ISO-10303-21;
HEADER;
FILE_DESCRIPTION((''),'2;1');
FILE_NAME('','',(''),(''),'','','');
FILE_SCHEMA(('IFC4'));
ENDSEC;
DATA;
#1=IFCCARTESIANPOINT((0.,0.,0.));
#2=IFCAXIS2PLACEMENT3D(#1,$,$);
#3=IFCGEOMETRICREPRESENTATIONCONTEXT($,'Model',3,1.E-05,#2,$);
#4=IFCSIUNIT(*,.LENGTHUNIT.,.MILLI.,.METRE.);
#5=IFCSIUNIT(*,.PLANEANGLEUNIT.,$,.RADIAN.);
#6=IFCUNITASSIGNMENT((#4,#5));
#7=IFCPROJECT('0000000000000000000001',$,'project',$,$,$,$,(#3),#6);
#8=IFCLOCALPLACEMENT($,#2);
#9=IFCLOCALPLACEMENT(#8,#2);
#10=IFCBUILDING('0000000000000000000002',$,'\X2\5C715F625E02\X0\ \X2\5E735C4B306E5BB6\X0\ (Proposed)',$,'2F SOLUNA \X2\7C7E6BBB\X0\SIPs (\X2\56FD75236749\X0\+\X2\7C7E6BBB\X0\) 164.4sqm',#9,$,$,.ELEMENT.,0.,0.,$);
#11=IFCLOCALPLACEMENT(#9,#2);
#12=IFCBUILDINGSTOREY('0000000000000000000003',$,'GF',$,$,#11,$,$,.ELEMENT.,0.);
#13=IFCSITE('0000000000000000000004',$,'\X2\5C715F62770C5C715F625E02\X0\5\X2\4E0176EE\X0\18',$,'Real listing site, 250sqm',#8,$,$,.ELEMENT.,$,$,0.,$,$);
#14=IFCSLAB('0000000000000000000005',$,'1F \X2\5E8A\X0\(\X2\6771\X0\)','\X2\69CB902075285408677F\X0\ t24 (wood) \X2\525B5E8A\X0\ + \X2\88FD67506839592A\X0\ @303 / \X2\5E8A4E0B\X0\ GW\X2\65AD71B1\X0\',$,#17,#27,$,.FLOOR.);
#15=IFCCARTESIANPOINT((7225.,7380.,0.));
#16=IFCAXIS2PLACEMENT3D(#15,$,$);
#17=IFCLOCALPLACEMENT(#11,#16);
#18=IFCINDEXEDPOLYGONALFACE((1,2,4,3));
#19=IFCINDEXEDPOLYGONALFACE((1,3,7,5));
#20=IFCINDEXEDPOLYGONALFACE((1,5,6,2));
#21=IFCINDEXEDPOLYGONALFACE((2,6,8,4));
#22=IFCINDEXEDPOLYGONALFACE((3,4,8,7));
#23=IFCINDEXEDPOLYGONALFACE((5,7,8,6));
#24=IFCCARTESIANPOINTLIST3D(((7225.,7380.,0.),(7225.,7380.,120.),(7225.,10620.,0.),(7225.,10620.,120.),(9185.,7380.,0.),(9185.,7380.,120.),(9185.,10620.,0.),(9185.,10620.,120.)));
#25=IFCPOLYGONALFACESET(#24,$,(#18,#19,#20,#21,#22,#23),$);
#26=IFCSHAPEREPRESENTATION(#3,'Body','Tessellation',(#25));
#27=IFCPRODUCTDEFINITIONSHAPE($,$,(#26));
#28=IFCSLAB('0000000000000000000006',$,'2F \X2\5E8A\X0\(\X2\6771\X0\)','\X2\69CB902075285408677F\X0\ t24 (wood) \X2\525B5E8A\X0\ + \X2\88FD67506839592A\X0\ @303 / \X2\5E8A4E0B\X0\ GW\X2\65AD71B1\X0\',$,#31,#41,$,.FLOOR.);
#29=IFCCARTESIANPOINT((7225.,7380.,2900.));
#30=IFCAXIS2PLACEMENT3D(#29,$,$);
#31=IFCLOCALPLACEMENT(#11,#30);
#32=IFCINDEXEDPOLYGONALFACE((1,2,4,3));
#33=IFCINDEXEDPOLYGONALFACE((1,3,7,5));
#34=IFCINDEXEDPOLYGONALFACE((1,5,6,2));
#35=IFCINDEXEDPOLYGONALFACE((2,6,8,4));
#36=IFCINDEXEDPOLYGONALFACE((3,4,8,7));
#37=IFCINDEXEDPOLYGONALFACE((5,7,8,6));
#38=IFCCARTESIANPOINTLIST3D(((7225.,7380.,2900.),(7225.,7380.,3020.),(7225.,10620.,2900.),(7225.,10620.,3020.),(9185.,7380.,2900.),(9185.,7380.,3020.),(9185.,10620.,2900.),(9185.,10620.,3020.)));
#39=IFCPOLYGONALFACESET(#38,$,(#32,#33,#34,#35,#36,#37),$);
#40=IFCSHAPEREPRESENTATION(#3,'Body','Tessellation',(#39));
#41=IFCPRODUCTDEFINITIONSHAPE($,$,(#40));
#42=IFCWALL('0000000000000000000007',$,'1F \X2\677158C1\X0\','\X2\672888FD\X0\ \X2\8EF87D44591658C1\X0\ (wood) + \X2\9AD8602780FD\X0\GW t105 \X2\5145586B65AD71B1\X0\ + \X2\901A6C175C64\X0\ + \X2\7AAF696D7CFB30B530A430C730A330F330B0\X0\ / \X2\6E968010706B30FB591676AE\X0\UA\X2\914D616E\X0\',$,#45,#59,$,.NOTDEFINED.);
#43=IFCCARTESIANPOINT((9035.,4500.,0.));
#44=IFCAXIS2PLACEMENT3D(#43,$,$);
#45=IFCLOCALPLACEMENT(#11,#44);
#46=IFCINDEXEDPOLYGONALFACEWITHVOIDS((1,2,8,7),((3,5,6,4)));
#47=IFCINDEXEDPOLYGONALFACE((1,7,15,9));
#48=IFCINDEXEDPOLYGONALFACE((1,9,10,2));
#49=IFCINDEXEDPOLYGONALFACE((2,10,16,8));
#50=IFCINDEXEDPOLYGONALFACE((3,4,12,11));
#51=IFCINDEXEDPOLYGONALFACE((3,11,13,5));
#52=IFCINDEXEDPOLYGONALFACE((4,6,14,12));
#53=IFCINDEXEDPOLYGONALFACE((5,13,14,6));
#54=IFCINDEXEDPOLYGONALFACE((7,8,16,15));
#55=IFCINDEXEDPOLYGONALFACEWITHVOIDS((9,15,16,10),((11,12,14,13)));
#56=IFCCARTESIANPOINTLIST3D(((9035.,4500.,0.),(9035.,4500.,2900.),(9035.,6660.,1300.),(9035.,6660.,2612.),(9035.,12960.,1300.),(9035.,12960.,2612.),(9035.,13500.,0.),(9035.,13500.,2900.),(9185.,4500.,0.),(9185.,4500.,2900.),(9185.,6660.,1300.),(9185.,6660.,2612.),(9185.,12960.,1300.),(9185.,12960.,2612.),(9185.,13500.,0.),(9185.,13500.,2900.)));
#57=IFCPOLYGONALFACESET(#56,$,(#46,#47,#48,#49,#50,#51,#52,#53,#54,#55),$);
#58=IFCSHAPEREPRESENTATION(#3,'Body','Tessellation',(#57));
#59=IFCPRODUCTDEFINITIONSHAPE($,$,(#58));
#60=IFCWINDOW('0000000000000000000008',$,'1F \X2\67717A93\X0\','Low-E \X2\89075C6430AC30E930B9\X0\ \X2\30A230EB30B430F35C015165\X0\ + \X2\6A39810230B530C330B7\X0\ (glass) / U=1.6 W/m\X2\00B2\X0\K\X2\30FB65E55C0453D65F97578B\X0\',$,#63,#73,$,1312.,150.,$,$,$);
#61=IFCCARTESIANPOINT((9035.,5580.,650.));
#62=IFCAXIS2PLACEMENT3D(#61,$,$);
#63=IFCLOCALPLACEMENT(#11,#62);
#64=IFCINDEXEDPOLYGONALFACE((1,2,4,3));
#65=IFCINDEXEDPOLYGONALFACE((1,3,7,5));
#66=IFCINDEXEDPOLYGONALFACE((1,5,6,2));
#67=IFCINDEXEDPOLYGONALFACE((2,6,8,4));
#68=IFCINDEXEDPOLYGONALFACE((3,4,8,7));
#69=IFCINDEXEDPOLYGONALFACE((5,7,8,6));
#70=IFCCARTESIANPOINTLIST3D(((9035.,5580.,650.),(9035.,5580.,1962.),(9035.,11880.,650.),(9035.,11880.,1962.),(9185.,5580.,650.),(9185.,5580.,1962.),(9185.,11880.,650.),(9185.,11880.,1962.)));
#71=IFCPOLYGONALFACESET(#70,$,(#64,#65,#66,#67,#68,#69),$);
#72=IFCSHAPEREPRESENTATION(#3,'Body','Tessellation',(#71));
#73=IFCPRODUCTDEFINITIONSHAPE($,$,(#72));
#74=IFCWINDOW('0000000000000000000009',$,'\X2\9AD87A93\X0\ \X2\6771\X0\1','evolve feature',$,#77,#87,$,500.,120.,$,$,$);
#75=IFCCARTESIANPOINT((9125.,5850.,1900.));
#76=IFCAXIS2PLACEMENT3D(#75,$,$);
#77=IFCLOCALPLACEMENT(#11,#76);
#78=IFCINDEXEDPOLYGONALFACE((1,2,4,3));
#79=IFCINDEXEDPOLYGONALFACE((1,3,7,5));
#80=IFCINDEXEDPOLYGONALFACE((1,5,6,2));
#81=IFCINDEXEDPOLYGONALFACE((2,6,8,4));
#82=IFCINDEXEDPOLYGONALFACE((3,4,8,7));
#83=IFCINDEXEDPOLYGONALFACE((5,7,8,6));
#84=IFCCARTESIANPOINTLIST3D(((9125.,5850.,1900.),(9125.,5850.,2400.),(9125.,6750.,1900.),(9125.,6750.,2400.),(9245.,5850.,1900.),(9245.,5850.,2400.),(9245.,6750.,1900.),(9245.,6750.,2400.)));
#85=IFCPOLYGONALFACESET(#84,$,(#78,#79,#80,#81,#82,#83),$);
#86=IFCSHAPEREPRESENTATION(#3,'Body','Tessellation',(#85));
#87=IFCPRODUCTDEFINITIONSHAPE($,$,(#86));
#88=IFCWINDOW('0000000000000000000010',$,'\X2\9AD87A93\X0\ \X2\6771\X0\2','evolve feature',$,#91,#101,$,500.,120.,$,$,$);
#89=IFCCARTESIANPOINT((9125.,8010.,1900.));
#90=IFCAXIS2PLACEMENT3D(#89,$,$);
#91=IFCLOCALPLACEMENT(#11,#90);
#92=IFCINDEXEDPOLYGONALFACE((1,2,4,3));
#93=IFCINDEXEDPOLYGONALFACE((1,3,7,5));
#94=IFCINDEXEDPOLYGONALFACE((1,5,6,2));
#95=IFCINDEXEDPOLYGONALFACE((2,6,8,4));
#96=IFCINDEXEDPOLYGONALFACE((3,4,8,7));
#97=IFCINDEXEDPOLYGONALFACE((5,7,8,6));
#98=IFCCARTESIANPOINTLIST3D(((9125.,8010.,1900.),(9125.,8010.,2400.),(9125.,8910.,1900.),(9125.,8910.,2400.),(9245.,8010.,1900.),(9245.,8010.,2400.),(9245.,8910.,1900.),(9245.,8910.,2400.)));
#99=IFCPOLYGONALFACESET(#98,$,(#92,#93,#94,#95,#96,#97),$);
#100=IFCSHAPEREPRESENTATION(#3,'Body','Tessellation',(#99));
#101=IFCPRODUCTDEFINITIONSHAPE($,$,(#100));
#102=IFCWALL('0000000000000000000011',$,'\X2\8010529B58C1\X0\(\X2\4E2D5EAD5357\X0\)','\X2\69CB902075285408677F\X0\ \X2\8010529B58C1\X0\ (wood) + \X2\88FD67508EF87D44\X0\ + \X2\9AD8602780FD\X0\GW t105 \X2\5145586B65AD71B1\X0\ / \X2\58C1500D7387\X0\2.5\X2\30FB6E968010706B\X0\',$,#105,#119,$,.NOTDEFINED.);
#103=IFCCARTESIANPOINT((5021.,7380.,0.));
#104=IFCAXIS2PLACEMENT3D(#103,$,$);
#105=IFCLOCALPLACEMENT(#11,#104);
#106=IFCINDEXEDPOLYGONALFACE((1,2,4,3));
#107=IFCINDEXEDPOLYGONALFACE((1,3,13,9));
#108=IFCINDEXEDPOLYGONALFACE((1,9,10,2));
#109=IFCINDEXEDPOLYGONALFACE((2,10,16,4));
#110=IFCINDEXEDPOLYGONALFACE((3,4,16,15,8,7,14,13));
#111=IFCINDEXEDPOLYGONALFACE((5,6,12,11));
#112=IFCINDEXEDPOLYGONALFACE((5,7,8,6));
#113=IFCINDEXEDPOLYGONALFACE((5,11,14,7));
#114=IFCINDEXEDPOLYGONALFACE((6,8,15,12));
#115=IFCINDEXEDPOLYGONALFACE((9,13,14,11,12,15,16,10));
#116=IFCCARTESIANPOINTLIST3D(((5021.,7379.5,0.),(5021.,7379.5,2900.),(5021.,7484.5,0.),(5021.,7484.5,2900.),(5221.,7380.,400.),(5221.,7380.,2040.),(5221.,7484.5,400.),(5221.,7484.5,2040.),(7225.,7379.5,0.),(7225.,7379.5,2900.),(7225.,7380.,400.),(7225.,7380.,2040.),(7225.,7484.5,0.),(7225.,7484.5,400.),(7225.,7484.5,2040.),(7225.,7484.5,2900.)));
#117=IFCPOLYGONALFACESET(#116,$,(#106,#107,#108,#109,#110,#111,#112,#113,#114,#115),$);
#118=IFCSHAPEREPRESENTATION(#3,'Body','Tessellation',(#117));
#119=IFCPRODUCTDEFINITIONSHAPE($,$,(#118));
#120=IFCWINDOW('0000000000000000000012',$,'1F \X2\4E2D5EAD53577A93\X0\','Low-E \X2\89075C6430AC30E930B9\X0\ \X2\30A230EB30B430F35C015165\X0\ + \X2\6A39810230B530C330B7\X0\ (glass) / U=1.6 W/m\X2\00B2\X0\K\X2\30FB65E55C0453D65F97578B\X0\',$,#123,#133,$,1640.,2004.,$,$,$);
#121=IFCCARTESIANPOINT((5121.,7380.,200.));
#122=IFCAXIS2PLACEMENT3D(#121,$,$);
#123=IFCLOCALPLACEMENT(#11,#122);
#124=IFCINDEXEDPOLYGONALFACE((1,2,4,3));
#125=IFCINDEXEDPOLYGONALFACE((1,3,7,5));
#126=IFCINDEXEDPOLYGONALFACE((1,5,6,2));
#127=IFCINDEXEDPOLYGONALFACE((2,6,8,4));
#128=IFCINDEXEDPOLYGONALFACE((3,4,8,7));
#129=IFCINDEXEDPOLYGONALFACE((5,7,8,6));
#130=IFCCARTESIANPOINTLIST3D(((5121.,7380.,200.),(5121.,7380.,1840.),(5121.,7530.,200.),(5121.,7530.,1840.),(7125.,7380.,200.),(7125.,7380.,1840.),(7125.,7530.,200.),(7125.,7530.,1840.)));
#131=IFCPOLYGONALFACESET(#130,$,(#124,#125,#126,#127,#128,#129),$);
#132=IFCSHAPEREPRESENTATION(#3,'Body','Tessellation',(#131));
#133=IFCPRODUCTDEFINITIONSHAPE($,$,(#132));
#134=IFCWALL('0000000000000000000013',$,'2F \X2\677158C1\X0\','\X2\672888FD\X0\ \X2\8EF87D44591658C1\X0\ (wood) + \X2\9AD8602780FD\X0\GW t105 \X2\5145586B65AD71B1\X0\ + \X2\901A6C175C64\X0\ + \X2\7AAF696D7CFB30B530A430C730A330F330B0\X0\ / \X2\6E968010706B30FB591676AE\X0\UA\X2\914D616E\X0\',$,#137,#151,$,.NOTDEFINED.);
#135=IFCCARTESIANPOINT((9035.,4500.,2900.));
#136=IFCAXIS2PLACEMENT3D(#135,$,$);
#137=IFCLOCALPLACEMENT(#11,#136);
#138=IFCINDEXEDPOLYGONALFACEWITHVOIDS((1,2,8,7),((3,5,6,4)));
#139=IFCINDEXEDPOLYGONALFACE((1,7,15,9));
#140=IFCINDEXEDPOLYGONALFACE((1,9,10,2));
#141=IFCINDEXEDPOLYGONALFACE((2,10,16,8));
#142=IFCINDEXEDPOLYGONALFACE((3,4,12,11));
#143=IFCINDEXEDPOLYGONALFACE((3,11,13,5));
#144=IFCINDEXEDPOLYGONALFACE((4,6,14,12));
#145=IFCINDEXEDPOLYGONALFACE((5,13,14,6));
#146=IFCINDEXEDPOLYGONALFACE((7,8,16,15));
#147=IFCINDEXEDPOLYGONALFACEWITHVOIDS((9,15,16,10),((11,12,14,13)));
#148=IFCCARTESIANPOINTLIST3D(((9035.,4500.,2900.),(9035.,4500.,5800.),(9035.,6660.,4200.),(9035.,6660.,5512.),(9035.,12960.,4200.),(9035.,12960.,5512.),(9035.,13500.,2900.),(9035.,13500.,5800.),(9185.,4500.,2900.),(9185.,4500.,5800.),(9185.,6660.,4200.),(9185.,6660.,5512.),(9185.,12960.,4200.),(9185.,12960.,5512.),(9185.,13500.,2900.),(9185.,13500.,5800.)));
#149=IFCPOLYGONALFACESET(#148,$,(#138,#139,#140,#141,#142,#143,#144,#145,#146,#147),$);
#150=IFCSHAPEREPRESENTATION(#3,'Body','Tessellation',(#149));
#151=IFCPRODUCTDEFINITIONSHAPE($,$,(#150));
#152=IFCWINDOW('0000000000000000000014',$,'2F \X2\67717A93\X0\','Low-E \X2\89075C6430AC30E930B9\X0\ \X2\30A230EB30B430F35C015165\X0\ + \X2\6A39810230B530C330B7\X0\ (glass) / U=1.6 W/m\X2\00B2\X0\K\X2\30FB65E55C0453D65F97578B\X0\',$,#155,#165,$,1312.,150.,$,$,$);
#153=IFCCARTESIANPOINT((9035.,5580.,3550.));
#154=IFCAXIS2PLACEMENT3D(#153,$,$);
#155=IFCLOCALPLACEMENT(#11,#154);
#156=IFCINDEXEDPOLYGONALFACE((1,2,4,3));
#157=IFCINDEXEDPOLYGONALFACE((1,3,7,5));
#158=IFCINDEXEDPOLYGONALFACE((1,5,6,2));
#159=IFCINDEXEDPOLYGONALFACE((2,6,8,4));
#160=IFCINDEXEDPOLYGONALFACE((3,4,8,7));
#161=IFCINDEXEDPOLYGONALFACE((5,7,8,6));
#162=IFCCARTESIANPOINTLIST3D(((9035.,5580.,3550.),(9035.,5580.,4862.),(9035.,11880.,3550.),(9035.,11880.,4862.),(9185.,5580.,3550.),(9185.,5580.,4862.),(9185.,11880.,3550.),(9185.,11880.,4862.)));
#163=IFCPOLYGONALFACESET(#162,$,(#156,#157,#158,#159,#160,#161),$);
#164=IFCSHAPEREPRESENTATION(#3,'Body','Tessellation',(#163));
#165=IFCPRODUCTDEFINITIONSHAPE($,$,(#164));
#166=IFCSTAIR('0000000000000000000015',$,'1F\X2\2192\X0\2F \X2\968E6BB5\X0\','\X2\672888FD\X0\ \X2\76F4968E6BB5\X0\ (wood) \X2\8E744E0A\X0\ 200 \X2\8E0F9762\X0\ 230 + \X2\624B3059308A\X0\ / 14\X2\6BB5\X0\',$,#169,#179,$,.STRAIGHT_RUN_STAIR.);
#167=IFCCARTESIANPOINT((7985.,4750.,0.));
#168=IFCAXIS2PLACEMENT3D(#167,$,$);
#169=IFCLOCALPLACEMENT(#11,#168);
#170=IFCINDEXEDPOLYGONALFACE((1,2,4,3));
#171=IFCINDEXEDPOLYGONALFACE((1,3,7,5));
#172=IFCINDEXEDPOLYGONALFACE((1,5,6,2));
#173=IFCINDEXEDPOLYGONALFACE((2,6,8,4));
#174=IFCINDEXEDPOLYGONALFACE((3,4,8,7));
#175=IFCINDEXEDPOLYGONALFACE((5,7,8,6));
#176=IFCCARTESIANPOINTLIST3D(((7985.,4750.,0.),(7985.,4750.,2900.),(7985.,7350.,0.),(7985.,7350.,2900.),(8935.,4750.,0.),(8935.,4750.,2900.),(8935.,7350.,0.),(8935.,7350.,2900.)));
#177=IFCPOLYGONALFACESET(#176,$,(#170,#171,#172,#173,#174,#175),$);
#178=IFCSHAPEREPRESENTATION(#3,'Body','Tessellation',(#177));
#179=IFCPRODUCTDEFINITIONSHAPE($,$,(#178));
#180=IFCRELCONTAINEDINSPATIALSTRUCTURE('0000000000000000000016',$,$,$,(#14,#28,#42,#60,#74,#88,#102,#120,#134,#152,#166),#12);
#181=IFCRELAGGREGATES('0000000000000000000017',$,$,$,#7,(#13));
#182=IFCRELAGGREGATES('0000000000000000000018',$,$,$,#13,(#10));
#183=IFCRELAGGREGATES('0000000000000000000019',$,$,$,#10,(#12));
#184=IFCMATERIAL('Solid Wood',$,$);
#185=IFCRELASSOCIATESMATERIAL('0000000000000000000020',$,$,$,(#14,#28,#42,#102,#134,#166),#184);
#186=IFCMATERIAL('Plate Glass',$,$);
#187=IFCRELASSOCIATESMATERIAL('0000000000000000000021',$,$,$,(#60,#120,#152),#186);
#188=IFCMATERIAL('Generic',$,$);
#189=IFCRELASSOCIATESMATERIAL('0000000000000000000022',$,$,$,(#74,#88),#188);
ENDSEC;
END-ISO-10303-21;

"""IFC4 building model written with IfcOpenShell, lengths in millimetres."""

from ifc_helpers import new_model, si_unit, frame, frame_2d, origin, place, context, project, spatial, rectangle, extrude, material, element, fill, save


model = new_model("IFC4")

# Units and contexts
model_context = context("Model", 3, precision=1e-05, world=origin())
ifc_project = project(units=[si_unit("LENGTHUNIT", "METRE", prefix="MILLI"), si_unit("PLANEANGLEUNIT", "RADIAN")], contexts=[model_context])

# Site, building, storey
site_placement = place(None, origin())
site = spatial("IfcSite", under=ifc_project, at=site_placement, Name="山形県山形市5丁目18", ObjectType="Real listing site, 250sqm", CompositionType="ELEMENT", RefElevation=0.0)
building_placement = place(site_placement, origin())
building = spatial("IfcBuilding", under=site, at=building_placement, Name="山形市 平屋の家 (Proposed)", ObjectType="2F SOLUNA 籾殻SIPs (国産杉+籾殻) 164.4sqm", CompositionType="ELEMENT", ElevationOfRefHeight=0.0, ElevationOfTerrain=0.0)
storey_placement = place(building_placement, origin())
storey = spatial("IfcBuildingStorey", under=building, at=storey_placement, Name="GF", CompositionType="ELEMENT", Elevation=0.0)

# Slabs
ifc_material_1 = material(Name="Solid Wood")
slab_1_placement = place(storey_placement, frame((7225.0, 7380.0, 0.0)))
element("IfcSlab", 1, at=slab_1_placement, inside=storey, material=ifc_material_1, Name="1F 床(東)", Description="構造用合板 t24 (wood) 剛床 + 製材根太 @303 / 床下 GW断熱", PredefinedType="FLOOR", context=model_context, shape_type="SweptSolid", body=[
    extrude(rectangle(XDim=1960.0, YDim=3240.0, at=frame_2d((980.0, 1620.0))), frame((7225.0, 7380.0, 0.0)), (0.0, 0.0, 1.0), 120.0),
])
slab_2_placement = place(storey_placement, frame((7225.0, 7380.0, 2900.0)))
element("IfcSlab", 2, at=slab_2_placement, inside=storey, material=ifc_material_1, Name="2F 床(東)", Description="構造用合板 t24 (wood) 剛床 + 製材根太 @303 / 床下 GW断熱", PredefinedType="FLOOR", context=model_context, shape_type="SweptSolid", body=[
    extrude(rectangle(XDim=1960.0, YDim=3240.0, at=frame_2d((980.0, 1620.0))), frame((7225.0, 7380.0, 2900.0)), (0.0, 0.0, 1.0), 120.0),
])

# Wall, openings, windows
wall_1_placement = place(storey_placement, frame((9035.0, 4500.0, 0.0)))
wall_1 = element("IfcWall", 3, at=wall_1_placement, inside=storey, material=ifc_material_1, Name="1F 東壁", Description="木製 軸組外壁 (wood) + 高性能GW t105 充填断熱 + 通気層 + 窯業系サイディング / 準耐火・外皮UA配慮", PredefinedType="NOTDEFINED", context=model_context, shape_type="SweptSolid", body=[
    extrude(rectangle(XDim=150.0, YDim=9000.0, at=frame_2d((75.0, 4500.0))), frame((9035.0, 4500.0, 0.0)), (0.0, 0.0, 1.0), 2900.0),
])
opening_1_placement = place(storey_placement, frame((9035.0, 5580.0, 650.0)))
opening_1 = element("IfcOpeningElement", 4, at=opening_1_placement, cuts=wall_1, PredefinedType="NOTDEFINED", context=model_context, shape_type="SweptSolid", body=[
    extrude(rectangle(XDim=150.0, YDim=6300.0, at=frame_2d((75.0, 3150.0))), frame((9035.0, 5580.0, 650.0)), (0.0, 0.0, 1.0), 1312.0),
])
opening_2_placement = place(storey_placement, frame((9125.0, 5850.0, 1900.0)))
opening_2 = element("IfcOpeningElement", 5, at=opening_2_placement, cuts=wall_1, PredefinedType="NOTDEFINED", context=model_context, shape_type="SweptSolid", body=[
    extrude(rectangle(XDim=120.0, YDim=900.0, at=frame_2d((60.0, 450.0))), frame((9125.0, 5850.0, 1900.0)), (0.0, 0.0, 1.0), 500.0),
])
opening_3_placement = place(storey_placement, frame((9125.0, 8010.0, 1900.0)))
opening_3 = element("IfcOpeningElement", 6, at=opening_3_placement, cuts=wall_1, PredefinedType="NOTDEFINED", context=model_context, shape_type="SweptSolid", body=[
    extrude(rectangle(XDim=120.0, YDim=900.0, at=frame_2d((60.0, 450.0))), frame((9125.0, 8010.0, 1900.0)), (0.0, 0.0, 1.0), 500.0),
])
ifc_material_2 = material(Name="Plate Glass")
window_1_placement = place(storey_placement, frame((9035.0, 5580.0, 650.0)))
window_1 = element("IfcWindow", 7, at=window_1_placement, inside=storey, material=ifc_material_2, Name="1F 東窓", Description="Low-E 複層ガラス アルゴン封入 + 樹脂サッシ (glass) / U=1.6 W/m²K・日射取得型", OverallHeight=1312.0, OverallWidth=150.0, context=model_context, shape_type="SweptSolid", body=[
    extrude(rectangle(XDim=150.0, YDim=6300.0, at=frame_2d((75.0, 3150.0))), frame((9035.0, 5580.0, 650.0)), (0.0, 0.0, 1.0), 1312.0),
])
fill(opening_1, window_1)
ifc_material_3 = material(Name="Generic")
window_2_placement = place(storey_placement, frame((9125.0, 5850.0, 1900.0)))
window_2 = element("IfcWindow", 8, at=window_2_placement, inside=storey, material=ifc_material_3, Name="高窓 東1", Description="evolve feature", OverallHeight=500.0, OverallWidth=120.0, context=model_context, shape_type="SweptSolid", body=[
    extrude(rectangle(XDim=120.0, YDim=900.0, at=frame_2d((60.0, 450.0))), frame((9125.0, 5850.0, 1900.0)), (0.0, 0.0, 1.0), 500.0),
])
fill(opening_2, window_2)
window_3_placement = place(storey_placement, frame((9125.0, 8010.0, 1900.0)))
window_3 = element("IfcWindow", 9, at=window_3_placement, inside=storey, material=ifc_material_3, Name="高窓 東2", Description="evolve feature", OverallHeight=500.0, OverallWidth=120.0, context=model_context, shape_type="SweptSolid", body=[
    extrude(rectangle(XDim=120.0, YDim=900.0, at=frame_2d((60.0, 450.0))), frame((9125.0, 8010.0, 1900.0)), (0.0, 0.0, 1.0), 500.0),
])
fill(opening_3, window_3)

# Wall, opening, window
wall_2_placement = place(storey_placement, frame((5021.0, 7380.0, 0.0)))
wall_2 = element("IfcWall", 10, at=wall_2_placement, inside=storey, material=ifc_material_1, Name="耐力壁(中庭南)", Description="構造用合板 耐力壁 (wood) + 製材軸組 + 高性能GW t105 充填断熱 / 壁倍率2.5・準耐火", PredefinedType="NOTDEFINED", context=model_context, shape_type="SweptSolid", body=[
    extrude(rectangle(XDim=2204.0, YDim=105.0, at=frame_2d((1102.0, 52.0))), frame((5021.0, 7380.0, 0.0)), (0.0, 0.0, 1.0), 2900.0),
])
opening_4_placement = place(storey_placement, frame((5121.0, 7380.0, 200.0)))
opening_4 = element("IfcOpeningElement", 11, at=opening_4_placement, cuts=wall_2, PredefinedType="NOTDEFINED", context=model_context, shape_type="SweptSolid", body=[
    extrude(rectangle(XDim=2004.0, YDim=150.0, at=frame_2d((1002.0, 75.0))), frame((5121.0, 7380.0, 200.0)), (0.0, 0.0, 1.0), 1640.0),
])
window_4_placement = place(storey_placement, frame((5121.0, 7380.0, 200.0)))
window_4 = element("IfcWindow", 12, at=window_4_placement, inside=storey, material=ifc_material_2, Name="1F 中庭南窓", Description="Low-E 複層ガラス アルゴン封入 + 樹脂サッシ (glass) / U=1.6 W/m²K・日射取得型", OverallHeight=1640.0, OverallWidth=2004.0, context=model_context, shape_type="SweptSolid", body=[
    extrude(rectangle(XDim=2004.0, YDim=150.0, at=frame_2d((1002.0, 75.0))), frame((5121.0, 7380.0, 200.0)), (0.0, 0.0, 1.0), 1640.0),
])
fill(opening_4, window_4)

# Wall, opening, window
wall_3_placement = place(storey_placement, frame((9035.0, 4500.0, 2900.0)))
wall_3 = element("IfcWall", 13, at=wall_3_placement, inside=storey, material=ifc_material_1, Name="2F 東壁", Description="木製 軸組外壁 (wood) + 高性能GW t105 充填断熱 + 通気層 + 窯業系サイディング / 準耐火・外皮UA配慮", PredefinedType="NOTDEFINED", context=model_context, shape_type="SweptSolid", body=[
    extrude(rectangle(XDim=150.0, YDim=9000.0, at=frame_2d((75.0, 4500.0))), frame((9035.0, 4500.0, 2900.0)), (0.0, 0.0, 1.0), 2900.0),
])
opening_5_placement = place(storey_placement, frame((9035.0, 5580.0, 3550.0)))
opening_5 = element("IfcOpeningElement", 14, at=opening_5_placement, cuts=wall_3, PredefinedType="NOTDEFINED", context=model_context, shape_type="SweptSolid", body=[
    extrude(rectangle(XDim=150.0, YDim=6300.0, at=frame_2d((75.0, 3150.0))), frame((9035.0, 5580.0, 3550.0)), (0.0, 0.0, 1.0), 1312.0),
])
window_5_placement = place(storey_placement, frame((9035.0, 5580.0, 3550.0)))
window_5 = element("IfcWindow", 15, at=window_5_placement, inside=storey, material=ifc_material_2, Name="2F 東窓", Description="Low-E 複層ガラス アルゴン封入 + 樹脂サッシ (glass) / U=1.6 W/m²K・日射取得型", OverallHeight=1312.0, OverallWidth=150.0, context=model_context, shape_type="SweptSolid", body=[
    extrude(rectangle(XDim=150.0, YDim=6300.0, at=frame_2d((75.0, 3150.0))), frame((9035.0, 5580.0, 3550.0)), (0.0, 0.0, 1.0), 1312.0),
])
fill(opening_5, window_5)

# Stair
stair_placement = place(storey_placement, frame((7985.0, 4750.0, 0.0)))
element("IfcStair", 16, at=stair_placement, inside=storey, material=ifc_material_1, Name="1F→2F 階段", Description="木製 直階段 (wood) 蹴上 200 踏面 230 + 手すり / 14段", PredefinedType="STRAIGHT_RUN_STAIR", context=model_context, shape_type="SweptSolid", body=[
    extrude(rectangle(XDim=950.0, YDim=2600.0, at=frame_2d((475.0, 1300.0))), frame((7985.0, 4750.0, 0.0)), (0.0, 0.0, 1.0), 2900.0),
])

save(model, "model.ifc")
